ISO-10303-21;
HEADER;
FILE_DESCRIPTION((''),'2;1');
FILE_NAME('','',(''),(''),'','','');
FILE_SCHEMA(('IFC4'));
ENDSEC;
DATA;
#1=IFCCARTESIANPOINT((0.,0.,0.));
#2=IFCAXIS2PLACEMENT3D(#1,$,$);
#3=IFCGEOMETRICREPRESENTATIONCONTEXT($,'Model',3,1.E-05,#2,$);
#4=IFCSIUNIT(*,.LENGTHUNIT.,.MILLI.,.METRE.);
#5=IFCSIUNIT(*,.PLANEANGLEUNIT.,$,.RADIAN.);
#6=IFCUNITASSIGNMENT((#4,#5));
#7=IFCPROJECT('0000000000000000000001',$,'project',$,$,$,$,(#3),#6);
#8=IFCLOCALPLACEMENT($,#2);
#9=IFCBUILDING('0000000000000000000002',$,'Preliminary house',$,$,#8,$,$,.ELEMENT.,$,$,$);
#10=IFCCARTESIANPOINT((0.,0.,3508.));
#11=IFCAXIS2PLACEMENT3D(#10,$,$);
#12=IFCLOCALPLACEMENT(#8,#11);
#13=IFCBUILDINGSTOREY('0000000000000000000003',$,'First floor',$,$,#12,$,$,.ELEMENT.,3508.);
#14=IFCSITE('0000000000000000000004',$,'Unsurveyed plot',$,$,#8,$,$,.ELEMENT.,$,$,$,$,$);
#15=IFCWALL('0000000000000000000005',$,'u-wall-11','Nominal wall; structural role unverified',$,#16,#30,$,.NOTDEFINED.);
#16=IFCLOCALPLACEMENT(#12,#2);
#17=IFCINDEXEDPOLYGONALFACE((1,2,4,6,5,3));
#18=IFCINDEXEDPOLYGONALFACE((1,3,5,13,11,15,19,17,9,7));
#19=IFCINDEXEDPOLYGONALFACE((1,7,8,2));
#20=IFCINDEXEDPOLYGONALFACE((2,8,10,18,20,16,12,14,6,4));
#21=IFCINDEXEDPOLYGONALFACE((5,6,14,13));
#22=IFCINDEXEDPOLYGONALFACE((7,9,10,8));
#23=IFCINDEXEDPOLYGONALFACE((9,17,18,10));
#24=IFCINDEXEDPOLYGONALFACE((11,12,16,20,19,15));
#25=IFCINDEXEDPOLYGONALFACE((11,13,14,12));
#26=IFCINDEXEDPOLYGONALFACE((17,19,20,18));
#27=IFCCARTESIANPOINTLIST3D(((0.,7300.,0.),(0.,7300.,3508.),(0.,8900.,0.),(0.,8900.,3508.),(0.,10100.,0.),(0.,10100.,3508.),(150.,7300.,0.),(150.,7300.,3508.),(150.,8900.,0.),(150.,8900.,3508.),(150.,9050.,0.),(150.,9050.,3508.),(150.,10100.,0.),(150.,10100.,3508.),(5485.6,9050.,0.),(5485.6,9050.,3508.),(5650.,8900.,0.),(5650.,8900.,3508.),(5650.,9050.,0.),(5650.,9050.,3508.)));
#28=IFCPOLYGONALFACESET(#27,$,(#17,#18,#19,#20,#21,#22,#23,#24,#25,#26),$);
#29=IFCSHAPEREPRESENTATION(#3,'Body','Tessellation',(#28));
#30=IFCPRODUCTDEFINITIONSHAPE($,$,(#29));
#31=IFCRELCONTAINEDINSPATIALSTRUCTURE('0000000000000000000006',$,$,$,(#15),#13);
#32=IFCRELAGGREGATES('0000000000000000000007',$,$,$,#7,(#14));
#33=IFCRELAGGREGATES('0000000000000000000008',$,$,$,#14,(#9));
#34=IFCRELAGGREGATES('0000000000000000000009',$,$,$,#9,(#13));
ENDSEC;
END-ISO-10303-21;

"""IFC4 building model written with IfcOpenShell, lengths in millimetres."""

from ifc_helpers import new_model, si_unit, frame, origin, place, context, project, spatial, polyline, outline, extrude, element, save


model = new_model("IFC4")

# Units and contexts
model_context = context("Model", 3, precision=1e-05, world=origin())
ifc_project = project(units=[si_unit("LENGTHUNIT", "METRE", prefix="MILLI"), si_unit("PLANEANGLEUNIT", "RADIAN")], contexts=[model_context])

# Site, building, storey
placement_1 = place(None, origin())
site = spatial("IfcSite", under=ifc_project, at=placement_1, Name="Unsurveyed plot", CompositionType="ELEMENT")
building = spatial("IfcBuilding", under=site, at=placement_1, Name="Preliminary house", CompositionType="ELEMENT")
placement_2 = place(placement_1, frame((0.0, 0.0, 3508.0)))
storey = spatial("IfcBuildingStorey", under=building, at=placement_2, Name="First floor", CompositionType="ELEMENT", Elevation=3508.0)

# Wall
element("IfcWall", 1, at=placement_2, inside=storey, Name="u-wall-11", Description="Nominal wall; structural role unverified", PredefinedType="NOTDEFINED", context=model_context, shape_type="SweptSolid", body=[
    extrude(outline(polyline([(0.0, 8900.0), (0.0, 10100.0), (150.0, 10100.0), (150.0, 9050.0), (5485.6, 9050.0), (5650.0, 9050.0), (5650.0, 8900.0), (150.0, 8900.0), (150.0, 7300.0), (0.0, 7300.0), (0.0, 8900.0)])), origin(), (0.0, 0.0, 1.0), 3508.0),
])

save(model, "model.ifc")
